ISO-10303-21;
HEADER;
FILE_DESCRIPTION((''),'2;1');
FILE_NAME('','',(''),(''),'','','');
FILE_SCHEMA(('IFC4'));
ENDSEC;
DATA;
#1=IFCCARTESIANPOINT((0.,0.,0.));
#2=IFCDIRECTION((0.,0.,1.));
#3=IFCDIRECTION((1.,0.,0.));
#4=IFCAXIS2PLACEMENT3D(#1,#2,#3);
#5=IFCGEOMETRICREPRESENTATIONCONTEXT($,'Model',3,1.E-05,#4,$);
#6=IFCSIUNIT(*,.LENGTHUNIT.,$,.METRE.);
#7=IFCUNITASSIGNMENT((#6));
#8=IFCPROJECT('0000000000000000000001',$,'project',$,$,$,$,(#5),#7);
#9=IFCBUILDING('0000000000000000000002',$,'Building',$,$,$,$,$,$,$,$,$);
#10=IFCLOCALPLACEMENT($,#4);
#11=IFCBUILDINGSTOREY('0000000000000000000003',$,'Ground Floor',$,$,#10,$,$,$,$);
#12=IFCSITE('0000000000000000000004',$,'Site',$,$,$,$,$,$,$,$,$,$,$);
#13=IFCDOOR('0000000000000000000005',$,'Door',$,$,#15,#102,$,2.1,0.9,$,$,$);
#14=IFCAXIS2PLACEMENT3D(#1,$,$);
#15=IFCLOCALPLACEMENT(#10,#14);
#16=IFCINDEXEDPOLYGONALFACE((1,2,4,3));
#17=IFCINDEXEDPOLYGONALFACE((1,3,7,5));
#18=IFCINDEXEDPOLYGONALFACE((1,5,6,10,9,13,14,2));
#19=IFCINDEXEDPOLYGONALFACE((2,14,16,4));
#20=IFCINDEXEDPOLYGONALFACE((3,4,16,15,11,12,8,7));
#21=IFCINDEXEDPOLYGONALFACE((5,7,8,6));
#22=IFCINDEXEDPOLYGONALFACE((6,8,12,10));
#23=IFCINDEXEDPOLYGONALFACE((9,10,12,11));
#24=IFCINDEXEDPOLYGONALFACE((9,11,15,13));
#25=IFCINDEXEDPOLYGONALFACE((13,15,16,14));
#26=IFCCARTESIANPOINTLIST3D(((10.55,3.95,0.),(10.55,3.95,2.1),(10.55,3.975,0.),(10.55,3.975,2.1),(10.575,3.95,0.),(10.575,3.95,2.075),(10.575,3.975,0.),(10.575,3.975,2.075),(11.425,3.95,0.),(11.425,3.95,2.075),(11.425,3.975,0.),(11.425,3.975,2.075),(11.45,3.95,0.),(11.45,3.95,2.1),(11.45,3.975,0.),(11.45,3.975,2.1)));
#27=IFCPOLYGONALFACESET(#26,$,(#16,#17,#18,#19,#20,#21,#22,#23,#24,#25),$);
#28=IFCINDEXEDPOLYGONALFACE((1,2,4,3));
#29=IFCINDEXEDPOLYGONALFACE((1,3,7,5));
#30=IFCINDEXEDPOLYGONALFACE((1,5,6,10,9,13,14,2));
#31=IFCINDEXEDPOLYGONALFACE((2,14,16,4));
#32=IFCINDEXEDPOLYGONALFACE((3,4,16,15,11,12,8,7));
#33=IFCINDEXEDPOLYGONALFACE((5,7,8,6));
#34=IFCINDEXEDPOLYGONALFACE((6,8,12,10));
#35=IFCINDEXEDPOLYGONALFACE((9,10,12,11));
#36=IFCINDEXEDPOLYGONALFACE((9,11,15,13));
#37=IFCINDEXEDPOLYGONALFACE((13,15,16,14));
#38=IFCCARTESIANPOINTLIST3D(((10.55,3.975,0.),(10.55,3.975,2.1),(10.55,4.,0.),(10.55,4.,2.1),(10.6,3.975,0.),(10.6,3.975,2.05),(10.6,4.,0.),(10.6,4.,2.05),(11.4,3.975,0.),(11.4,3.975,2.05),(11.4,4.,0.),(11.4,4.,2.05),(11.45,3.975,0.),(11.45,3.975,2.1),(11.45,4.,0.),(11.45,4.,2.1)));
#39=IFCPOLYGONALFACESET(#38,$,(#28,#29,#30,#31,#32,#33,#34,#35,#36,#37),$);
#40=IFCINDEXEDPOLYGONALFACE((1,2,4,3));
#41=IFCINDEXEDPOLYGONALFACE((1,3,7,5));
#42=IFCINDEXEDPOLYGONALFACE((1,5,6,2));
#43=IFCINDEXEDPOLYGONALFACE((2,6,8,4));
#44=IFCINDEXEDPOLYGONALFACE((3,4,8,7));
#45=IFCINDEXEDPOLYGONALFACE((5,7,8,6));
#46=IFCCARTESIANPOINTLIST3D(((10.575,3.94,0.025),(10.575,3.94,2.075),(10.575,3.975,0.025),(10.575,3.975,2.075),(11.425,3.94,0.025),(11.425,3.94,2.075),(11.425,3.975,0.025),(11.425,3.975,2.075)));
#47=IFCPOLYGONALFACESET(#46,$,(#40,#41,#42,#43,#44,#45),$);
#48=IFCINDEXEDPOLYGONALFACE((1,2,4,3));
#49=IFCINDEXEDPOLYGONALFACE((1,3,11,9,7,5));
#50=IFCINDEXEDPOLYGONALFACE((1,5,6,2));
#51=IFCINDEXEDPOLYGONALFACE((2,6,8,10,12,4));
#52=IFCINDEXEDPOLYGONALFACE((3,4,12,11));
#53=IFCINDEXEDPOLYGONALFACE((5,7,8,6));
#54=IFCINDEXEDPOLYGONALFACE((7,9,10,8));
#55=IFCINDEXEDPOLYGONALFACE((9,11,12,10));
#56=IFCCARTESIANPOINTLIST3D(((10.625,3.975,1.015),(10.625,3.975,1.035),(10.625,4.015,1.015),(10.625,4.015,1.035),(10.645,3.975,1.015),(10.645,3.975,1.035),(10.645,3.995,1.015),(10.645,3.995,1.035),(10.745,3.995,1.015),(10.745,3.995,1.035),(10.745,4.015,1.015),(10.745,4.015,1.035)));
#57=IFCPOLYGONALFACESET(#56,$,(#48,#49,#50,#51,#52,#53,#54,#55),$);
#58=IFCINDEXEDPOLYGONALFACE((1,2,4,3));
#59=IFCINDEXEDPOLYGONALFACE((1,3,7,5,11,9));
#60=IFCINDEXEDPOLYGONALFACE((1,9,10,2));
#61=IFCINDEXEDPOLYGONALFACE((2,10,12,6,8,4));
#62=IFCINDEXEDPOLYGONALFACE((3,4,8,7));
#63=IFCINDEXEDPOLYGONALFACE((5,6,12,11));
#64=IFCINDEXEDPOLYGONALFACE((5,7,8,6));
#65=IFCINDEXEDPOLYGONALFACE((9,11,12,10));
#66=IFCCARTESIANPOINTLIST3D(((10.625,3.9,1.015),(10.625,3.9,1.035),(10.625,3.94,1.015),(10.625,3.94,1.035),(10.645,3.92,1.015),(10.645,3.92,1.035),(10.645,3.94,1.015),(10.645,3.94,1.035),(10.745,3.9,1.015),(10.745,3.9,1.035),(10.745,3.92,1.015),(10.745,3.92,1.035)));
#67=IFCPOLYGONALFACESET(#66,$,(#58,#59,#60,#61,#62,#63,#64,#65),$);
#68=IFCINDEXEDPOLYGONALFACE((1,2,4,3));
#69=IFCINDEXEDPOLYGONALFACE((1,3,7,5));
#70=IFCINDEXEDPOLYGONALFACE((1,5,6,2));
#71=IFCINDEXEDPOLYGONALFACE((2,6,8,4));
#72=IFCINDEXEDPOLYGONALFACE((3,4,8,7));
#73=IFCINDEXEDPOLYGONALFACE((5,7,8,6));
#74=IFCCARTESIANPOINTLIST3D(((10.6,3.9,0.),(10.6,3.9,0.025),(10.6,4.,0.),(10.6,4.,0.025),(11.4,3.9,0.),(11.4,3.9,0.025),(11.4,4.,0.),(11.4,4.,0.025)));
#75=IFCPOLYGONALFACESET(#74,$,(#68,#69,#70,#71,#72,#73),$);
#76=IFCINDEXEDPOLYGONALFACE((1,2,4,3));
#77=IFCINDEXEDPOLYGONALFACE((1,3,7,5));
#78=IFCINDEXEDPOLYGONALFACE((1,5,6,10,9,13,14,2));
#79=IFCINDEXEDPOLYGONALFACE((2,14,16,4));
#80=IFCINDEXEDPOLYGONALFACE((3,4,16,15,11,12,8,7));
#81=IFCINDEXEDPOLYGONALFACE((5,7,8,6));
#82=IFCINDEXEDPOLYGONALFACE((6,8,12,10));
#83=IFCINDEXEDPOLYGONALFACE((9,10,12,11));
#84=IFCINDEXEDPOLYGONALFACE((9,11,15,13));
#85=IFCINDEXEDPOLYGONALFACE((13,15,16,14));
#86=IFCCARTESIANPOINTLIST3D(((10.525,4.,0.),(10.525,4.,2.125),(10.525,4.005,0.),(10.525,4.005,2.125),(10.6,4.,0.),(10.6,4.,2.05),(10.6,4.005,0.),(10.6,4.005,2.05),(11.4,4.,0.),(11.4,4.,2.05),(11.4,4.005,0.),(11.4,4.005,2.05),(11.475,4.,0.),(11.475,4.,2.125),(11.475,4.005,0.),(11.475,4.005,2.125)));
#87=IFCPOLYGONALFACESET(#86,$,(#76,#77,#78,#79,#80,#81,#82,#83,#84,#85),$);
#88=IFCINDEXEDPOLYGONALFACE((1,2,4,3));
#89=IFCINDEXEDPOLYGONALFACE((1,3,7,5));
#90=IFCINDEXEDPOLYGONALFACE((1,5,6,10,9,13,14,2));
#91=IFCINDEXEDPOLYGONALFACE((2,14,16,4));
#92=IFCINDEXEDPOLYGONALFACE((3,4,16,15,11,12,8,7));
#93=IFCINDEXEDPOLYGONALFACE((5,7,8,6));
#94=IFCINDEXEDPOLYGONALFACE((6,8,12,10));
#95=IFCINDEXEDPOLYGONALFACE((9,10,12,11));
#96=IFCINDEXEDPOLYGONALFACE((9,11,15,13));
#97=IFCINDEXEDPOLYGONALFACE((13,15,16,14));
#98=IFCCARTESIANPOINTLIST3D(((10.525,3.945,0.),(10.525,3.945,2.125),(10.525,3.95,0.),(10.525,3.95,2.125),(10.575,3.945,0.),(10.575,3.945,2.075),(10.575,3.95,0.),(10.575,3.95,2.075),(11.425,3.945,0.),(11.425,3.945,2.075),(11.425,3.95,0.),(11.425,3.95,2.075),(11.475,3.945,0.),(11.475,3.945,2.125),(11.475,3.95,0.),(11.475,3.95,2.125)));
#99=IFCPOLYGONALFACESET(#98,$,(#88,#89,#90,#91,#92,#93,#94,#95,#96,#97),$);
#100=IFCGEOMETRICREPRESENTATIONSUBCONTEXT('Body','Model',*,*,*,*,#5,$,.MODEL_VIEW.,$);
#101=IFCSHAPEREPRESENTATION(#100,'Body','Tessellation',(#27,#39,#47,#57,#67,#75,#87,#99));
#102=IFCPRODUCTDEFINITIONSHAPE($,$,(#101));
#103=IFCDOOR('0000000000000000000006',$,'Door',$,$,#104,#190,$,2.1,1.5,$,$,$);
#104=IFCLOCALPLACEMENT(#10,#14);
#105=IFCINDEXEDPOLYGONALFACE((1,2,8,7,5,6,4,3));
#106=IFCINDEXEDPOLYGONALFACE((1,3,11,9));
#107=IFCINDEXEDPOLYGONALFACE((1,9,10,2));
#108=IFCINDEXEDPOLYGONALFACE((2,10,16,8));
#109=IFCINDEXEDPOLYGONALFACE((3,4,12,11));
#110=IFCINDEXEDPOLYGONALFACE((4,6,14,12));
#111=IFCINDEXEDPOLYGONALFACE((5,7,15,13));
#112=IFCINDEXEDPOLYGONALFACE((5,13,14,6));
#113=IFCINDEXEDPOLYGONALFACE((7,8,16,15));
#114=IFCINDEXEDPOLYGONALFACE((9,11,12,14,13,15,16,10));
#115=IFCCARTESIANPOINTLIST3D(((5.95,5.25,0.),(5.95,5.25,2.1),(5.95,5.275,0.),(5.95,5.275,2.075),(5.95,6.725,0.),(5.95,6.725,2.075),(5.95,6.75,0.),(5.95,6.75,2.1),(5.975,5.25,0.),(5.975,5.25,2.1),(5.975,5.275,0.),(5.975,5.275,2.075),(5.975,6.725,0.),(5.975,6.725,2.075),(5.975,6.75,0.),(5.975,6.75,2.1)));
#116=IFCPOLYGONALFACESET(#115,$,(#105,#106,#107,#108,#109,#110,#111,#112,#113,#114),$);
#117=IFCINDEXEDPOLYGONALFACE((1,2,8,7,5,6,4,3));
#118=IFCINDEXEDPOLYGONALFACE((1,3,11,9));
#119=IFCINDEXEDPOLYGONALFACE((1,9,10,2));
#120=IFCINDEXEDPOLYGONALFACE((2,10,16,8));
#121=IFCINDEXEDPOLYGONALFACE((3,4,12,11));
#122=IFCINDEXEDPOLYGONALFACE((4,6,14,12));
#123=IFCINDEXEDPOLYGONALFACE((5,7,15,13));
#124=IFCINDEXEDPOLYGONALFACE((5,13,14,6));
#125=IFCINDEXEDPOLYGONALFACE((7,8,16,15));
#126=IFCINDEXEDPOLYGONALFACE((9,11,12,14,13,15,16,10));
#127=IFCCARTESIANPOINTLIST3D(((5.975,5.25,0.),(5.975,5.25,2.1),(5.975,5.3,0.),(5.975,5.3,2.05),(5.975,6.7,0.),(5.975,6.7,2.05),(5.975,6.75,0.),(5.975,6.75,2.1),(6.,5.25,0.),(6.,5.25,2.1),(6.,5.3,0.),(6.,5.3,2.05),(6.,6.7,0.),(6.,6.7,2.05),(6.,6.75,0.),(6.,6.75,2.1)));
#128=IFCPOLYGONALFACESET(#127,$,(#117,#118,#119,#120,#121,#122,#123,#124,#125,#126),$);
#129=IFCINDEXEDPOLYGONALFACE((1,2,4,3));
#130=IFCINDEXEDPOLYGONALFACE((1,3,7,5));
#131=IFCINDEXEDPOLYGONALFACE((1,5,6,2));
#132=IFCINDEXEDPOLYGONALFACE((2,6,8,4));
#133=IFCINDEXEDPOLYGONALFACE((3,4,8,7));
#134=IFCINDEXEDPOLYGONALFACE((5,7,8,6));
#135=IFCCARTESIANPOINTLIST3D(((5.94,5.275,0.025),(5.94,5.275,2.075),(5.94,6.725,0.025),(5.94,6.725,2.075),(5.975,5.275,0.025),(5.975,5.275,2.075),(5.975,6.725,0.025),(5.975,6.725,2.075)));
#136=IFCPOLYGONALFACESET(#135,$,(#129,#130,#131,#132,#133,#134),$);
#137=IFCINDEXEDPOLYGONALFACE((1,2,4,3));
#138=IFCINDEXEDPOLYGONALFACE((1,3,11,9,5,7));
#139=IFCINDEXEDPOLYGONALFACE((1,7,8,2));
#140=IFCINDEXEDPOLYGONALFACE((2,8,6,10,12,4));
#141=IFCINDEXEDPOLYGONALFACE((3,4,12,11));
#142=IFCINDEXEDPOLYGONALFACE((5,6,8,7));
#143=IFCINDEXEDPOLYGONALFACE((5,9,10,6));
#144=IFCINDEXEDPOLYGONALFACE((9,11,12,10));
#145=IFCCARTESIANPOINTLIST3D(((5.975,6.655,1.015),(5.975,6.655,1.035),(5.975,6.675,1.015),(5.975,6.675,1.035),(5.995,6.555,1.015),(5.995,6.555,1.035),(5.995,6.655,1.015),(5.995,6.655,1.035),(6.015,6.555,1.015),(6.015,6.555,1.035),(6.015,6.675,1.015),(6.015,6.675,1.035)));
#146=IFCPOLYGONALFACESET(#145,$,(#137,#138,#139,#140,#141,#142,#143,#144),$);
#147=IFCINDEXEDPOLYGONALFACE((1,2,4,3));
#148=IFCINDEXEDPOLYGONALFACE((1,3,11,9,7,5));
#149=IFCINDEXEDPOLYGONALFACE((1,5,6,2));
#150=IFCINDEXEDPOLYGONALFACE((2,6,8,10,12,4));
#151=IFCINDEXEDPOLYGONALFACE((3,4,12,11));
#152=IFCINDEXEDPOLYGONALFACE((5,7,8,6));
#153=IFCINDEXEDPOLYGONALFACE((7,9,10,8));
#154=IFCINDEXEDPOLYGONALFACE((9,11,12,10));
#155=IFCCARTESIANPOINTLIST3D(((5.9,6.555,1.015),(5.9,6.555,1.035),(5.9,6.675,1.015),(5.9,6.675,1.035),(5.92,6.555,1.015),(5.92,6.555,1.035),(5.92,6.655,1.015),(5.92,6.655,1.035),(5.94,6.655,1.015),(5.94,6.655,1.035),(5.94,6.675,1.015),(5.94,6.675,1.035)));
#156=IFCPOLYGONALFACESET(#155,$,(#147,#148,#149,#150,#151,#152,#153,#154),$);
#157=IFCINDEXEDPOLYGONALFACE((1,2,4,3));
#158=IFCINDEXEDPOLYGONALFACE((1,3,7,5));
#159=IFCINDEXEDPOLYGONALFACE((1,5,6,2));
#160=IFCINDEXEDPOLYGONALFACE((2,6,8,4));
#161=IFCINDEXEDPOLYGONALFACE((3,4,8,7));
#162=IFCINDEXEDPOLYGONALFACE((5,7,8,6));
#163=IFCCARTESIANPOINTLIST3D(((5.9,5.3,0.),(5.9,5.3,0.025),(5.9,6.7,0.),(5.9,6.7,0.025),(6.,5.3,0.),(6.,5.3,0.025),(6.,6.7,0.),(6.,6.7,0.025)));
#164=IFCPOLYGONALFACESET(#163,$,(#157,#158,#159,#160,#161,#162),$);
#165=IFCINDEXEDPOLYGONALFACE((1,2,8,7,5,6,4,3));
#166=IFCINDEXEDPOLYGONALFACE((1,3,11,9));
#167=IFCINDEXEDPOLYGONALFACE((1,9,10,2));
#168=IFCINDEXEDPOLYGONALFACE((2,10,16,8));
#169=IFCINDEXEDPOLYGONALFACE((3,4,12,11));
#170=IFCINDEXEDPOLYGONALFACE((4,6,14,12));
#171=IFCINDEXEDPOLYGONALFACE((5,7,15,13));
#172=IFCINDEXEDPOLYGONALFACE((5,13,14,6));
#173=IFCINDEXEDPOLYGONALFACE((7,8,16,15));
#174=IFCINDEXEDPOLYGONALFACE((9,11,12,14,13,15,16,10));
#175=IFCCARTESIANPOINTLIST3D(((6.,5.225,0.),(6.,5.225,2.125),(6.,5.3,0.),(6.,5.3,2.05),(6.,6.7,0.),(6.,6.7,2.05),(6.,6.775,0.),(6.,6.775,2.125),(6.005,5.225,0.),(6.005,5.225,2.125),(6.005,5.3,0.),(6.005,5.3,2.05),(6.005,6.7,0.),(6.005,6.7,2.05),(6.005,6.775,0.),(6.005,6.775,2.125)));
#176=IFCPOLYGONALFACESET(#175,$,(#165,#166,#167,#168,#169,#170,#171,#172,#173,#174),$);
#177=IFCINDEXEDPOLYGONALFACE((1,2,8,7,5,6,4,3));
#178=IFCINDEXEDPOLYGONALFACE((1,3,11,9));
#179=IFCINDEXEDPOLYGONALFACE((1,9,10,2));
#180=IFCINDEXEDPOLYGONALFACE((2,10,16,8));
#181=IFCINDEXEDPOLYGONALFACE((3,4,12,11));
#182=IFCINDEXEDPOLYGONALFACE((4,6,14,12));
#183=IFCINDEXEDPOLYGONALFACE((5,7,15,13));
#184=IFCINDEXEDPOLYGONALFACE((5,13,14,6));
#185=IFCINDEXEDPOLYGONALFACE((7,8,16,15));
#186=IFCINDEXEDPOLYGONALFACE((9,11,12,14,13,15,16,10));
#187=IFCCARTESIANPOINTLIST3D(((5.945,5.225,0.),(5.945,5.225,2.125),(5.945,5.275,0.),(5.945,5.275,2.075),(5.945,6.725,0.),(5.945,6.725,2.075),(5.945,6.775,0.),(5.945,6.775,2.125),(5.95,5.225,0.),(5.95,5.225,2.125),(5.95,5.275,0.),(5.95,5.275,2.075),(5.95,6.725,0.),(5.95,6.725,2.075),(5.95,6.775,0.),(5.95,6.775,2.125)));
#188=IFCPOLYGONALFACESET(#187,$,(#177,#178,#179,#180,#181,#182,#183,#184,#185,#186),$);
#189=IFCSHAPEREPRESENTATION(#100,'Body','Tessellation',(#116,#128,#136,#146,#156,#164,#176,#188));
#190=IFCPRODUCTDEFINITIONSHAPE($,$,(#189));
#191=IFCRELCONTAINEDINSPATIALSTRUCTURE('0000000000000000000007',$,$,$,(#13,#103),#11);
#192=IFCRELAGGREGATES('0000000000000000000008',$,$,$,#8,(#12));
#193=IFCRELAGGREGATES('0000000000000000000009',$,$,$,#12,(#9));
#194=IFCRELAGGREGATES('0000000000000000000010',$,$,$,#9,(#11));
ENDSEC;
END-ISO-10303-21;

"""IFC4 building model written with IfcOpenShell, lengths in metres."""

from ifc_helpers import new_model, si_unit, frame, origin_with_axes, place, context, subcontext, project, spatial, line, indexed_curve, outline, extrude, element, save


model = new_model("IFC4")

# Units and contexts
model_context = context("Model", 3, precision=1e-05, world=origin_with_axes())
body_context = subcontext(model_context, "Body", "Model", "MODEL_VIEW")
ifc_project = project(units=[si_unit("LENGTHUNIT", "METRE")], contexts=[model_context])

# Site, building, storey
site = spatial("IfcSite", under=ifc_project, Name="Site")
building = spatial("IfcBuilding", under=site, Name="Building")
storey_placement = place(None, origin_with_axes())
storey = spatial("IfcBuildingStorey", under=building, at=storey_placement, Name="Ground Floor")

# Doors
door_1_placement = place(storey_placement, frame((11.45, 4.0, 0.0), z_axis=(0.0, 0.0, 1.0), x_axis=(-1.0, 0.0, 0.0)))
element("IfcDoor", 1, at=door_1_placement, inside=storey, Name="Door", OverallHeight=2.1, OverallWidth=0.9, context=body_context, shape_type="SweptSolid", body=[
    extrude(outline(indexed_curve([(0.0, 0.0), (0.0, 2.1), (0.9, 2.1), (0.9, 0.0), (0.875, 0.0), (0.875, 2.075), (0.025, 2.075), (0.025, 0.0)], segments=[line(1, 2, 3, 4, 5, 6, 7, 8, 1)])), frame((0.0, 0.025, 0.0), z_axis=(0.0, -1.0, 0.0), x_axis=(1.0, 0.0, 0.0)), (0.0, 0.0, -1.0), 0.025),
    extrude(outline(indexed_curve([(0.0, 0.0), (0.0, 2.1), (0.9, 2.1), (0.9, 0.0), (0.85, 0.0), (0.85, 2.05), (0.05, 2.05), (0.05, 0.0)], segments=[line(1, 2, 3, 4, 5, 6, 7, 8, 1)])), frame((0.0, 0.0, 0.0), z_axis=(0.0, -1.0, 0.0), x_axis=(1.0, 0.0, 0.0)), (0.0, 0.0, -1.0), 0.025),
    extrude(outline(indexed_curve([(0.0, 0.0), (0.85, 0.0), (0.85, 0.035), (0.0, 0.035)], segments=[line(1, 2, 3, 4, 1)])), frame((0.025, 0.025, 0.025), z_axis=(0.0, 0.0, 1.0), x_axis=(1.0, 0.0, 0.0)), (0.0, 0.0, 1.0), 2.05),
    extrude(outline(indexed_curve([(0.0, 0.0), (0.0, -0.04), (-0.12, -0.04), (-0.12, -0.02), (-0.02, -0.02), (-0.02, 0.0)], segments=[line(1, 2, 3, 4, 5, 6, 1)])), frame((0.825, 0.025, 1.015), z_axis=(0.0, 0.0, 1.0), x_axis=(1.0, 0.0, 0.0)), (0.0, 0.0, 1.0), 0.02),
    extrude(outline(indexed_curve([(0.0, 0.0), (0.0, 0.04), (-0.12, 0.04), (-0.12, 0.02), (-0.02, 0.02), (-0.02, 0.0)], segments=[line(1, 2, 3, 4, 5, 6, 1)])), frame((0.825, 0.06, 1.015), z_axis=(0.0, 0.0, 1.0), x_axis=(1.0, 0.0, 0.0)), (0.0, 0.0, 1.0), 0.02),
    extrude(outline(indexed_curve([(0.0, 0.0), (0.8, 0.0), (0.8, 0.1), (0.0, 0.1)], segments=[line(1, 2, 3, 4, 1)])), frame((0.05, 0.0, 0.0), z_axis=(0.0, 0.0, 1.0), x_axis=(1.0, 0.0, 0.0)), (0.0, 0.0, 1.0), 0.025),
    extrude(outline(indexed_curve([(0.0, 0.0), (0.0, 2.125), (0.95, 2.125), (0.95, 0.0), (0.875, 0.0), (0.875, 2.05), (0.075, 2.05), (0.075, 0.0)], segments=[line(1, 2, 3, 4, 5, 6, 7, 8, 1)])), frame((-0.025, -0.005, 0.0), z_axis=(0.0, -1.0, 0.0), x_axis=(1.0, 0.0, 0.0)), (0.0, 0.0, -1.0), 0.005),
    extrude(outline(indexed_curve([(0.0, 0.0), (0.0, 2.125), (0.95, 2.125), (0.95, 0.0), (0.9, 0.0), (0.9, 2.075), (0.05, 2.075), (0.05, 0.0)], segments=[line(1, 2, 3, 4, 5, 6, 7, 8, 1)])), frame((-0.025, 0.05, 0.0), z_axis=(0.0, -1.0, 0.0), x_axis=(1.0, 0.0, 0.0)), (0.0, 0.0, -1.0), 0.005),
])
door_2_placement = place(storey_placement, frame((6.0, 5.25, 0.0), z_axis=(0.0, 0.0, 1.0), x_axis=(0.0, 1.0, 0.0)))
element("IfcDoor", 2, at=door_2_placement, inside=storey, Name="Door", OverallHeight=2.1, OverallWidth=1.5, context=body_context, shape_type="SweptSolid", body=[
    extrude(outline(indexed_curve([(0.0, 0.0), (0.0, 2.1), (1.5, 2.1), (1.5, 0.0), (1.475, 0.0), (1.475, 2.075), (0.025, 2.075), (0.025, 0.0)], segments=[line(1, 2, 3, 4, 5, 6, 7, 8, 1)])), frame((0.0, 0.025, 0.0), z_axis=(0.0, -1.0, 0.0), x_axis=(1.0, 0.0, 0.0)), (0.0, 0.0, -1.0), 0.025),
    extrude(outline(indexed_curve([(0.0, 0.0), (0.0, 2.1), (1.5, 2.1), (1.5, 0.0), (1.45, 0.0), (1.45, 2.05), (0.05, 2.05), (0.05, 0.0)], segments=[line(1, 2, 3, 4, 5, 6, 7, 8, 1)])), frame((0.0, 0.0, 0.0), z_axis=(0.0, -1.0, 0.0), x_axis=(1.0, 0.0, 0.0)), (0.0, 0.0, -1.0), 0.025),
    extrude(outline(indexed_curve([(0.0, 0.0), (1.45, 0.0), (1.45, 0.035), (0.0, 0.035)], segments=[line(1, 2, 3, 4, 1)])), frame((0.025, 0.025, 0.025), z_axis=(0.0, 0.0, 1.0), x_axis=(1.0, 0.0, 0.0)), (0.0, 0.0, 1.0), 2.05),
    extrude(outline(indexed_curve([(0.0, 0.0), (0.0, -0.04), (-0.12, -0.04), (-0.12, -0.02), (-0.02, -0.02), (-0.02, 0.0)], segments=[line(1, 2, 3, 4, 5, 6, 1)])), frame((1.425, 0.025, 1.015), z_axis=(0.0, 0.0, 1.0), x_axis=(1.0, 0.0, 0.0)), (0.0, 0.0, 1.0), 0.02),
    extrude(outline(indexed_curve([(0.0, 0.0), (0.0, 0.04), (-0.12, 0.04), (-0.12, 0.02), (-0.02, 0.02), (-0.02, 0.0)], segments=[line(1, 2, 3, 4, 5, 6, 1)])), frame((1.425, 0.06, 1.015), z_axis=(0.0, 0.0, 1.0), x_axis=(1.0, 0.0, 0.0)), (0.0, 0.0, 1.0), 0.02),
    extrude(outline(indexed_curve([(0.0, 0.0), (1.4, 0.0), (1.4, 0.1), (0.0, 0.1)], segments=[line(1, 2, 3, 4, 1)])), frame((0.05, 0.0, 0.0), z_axis=(0.0, 0.0, 1.0), x_axis=(1.0, 0.0, 0.0)), (0.0, 0.0, 1.0), 0.025),
    extrude(outline(indexed_curve([(0.0, 0.0), (0.0, 2.125), (1.55, 2.125), (1.55, 0.0), (1.475, 0.0), (1.475, 2.05), (0.075, 2.05), (0.075, 0.0)], segments=[line(1, 2, 3, 4, 5, 6, 7, 8, 1)])), frame((-0.025, -0.005, 0.0), z_axis=(0.0, -1.0, 0.0), x_axis=(1.0, 0.0, 0.0)), (0.0, 0.0, -1.0), 0.005),
    extrude(outline(indexed_curve([(0.0, 0.0), (0.0, 2.125), (1.55, 2.125), (1.55, 0.0), (1.5, 0.0), (1.5, 2.075), (0.05, 2.075), (0.05, 0.0)], segments=[line(1, 2, 3, 4, 5, 6, 7, 8, 1)])), frame((-0.025, 0.05, 0.0), z_axis=(0.0, -1.0, 0.0), x_axis=(1.0, 0.0, 0.0)), (0.0, 0.0, -1.0), 0.005),
])

save(model, "model.ifc")
